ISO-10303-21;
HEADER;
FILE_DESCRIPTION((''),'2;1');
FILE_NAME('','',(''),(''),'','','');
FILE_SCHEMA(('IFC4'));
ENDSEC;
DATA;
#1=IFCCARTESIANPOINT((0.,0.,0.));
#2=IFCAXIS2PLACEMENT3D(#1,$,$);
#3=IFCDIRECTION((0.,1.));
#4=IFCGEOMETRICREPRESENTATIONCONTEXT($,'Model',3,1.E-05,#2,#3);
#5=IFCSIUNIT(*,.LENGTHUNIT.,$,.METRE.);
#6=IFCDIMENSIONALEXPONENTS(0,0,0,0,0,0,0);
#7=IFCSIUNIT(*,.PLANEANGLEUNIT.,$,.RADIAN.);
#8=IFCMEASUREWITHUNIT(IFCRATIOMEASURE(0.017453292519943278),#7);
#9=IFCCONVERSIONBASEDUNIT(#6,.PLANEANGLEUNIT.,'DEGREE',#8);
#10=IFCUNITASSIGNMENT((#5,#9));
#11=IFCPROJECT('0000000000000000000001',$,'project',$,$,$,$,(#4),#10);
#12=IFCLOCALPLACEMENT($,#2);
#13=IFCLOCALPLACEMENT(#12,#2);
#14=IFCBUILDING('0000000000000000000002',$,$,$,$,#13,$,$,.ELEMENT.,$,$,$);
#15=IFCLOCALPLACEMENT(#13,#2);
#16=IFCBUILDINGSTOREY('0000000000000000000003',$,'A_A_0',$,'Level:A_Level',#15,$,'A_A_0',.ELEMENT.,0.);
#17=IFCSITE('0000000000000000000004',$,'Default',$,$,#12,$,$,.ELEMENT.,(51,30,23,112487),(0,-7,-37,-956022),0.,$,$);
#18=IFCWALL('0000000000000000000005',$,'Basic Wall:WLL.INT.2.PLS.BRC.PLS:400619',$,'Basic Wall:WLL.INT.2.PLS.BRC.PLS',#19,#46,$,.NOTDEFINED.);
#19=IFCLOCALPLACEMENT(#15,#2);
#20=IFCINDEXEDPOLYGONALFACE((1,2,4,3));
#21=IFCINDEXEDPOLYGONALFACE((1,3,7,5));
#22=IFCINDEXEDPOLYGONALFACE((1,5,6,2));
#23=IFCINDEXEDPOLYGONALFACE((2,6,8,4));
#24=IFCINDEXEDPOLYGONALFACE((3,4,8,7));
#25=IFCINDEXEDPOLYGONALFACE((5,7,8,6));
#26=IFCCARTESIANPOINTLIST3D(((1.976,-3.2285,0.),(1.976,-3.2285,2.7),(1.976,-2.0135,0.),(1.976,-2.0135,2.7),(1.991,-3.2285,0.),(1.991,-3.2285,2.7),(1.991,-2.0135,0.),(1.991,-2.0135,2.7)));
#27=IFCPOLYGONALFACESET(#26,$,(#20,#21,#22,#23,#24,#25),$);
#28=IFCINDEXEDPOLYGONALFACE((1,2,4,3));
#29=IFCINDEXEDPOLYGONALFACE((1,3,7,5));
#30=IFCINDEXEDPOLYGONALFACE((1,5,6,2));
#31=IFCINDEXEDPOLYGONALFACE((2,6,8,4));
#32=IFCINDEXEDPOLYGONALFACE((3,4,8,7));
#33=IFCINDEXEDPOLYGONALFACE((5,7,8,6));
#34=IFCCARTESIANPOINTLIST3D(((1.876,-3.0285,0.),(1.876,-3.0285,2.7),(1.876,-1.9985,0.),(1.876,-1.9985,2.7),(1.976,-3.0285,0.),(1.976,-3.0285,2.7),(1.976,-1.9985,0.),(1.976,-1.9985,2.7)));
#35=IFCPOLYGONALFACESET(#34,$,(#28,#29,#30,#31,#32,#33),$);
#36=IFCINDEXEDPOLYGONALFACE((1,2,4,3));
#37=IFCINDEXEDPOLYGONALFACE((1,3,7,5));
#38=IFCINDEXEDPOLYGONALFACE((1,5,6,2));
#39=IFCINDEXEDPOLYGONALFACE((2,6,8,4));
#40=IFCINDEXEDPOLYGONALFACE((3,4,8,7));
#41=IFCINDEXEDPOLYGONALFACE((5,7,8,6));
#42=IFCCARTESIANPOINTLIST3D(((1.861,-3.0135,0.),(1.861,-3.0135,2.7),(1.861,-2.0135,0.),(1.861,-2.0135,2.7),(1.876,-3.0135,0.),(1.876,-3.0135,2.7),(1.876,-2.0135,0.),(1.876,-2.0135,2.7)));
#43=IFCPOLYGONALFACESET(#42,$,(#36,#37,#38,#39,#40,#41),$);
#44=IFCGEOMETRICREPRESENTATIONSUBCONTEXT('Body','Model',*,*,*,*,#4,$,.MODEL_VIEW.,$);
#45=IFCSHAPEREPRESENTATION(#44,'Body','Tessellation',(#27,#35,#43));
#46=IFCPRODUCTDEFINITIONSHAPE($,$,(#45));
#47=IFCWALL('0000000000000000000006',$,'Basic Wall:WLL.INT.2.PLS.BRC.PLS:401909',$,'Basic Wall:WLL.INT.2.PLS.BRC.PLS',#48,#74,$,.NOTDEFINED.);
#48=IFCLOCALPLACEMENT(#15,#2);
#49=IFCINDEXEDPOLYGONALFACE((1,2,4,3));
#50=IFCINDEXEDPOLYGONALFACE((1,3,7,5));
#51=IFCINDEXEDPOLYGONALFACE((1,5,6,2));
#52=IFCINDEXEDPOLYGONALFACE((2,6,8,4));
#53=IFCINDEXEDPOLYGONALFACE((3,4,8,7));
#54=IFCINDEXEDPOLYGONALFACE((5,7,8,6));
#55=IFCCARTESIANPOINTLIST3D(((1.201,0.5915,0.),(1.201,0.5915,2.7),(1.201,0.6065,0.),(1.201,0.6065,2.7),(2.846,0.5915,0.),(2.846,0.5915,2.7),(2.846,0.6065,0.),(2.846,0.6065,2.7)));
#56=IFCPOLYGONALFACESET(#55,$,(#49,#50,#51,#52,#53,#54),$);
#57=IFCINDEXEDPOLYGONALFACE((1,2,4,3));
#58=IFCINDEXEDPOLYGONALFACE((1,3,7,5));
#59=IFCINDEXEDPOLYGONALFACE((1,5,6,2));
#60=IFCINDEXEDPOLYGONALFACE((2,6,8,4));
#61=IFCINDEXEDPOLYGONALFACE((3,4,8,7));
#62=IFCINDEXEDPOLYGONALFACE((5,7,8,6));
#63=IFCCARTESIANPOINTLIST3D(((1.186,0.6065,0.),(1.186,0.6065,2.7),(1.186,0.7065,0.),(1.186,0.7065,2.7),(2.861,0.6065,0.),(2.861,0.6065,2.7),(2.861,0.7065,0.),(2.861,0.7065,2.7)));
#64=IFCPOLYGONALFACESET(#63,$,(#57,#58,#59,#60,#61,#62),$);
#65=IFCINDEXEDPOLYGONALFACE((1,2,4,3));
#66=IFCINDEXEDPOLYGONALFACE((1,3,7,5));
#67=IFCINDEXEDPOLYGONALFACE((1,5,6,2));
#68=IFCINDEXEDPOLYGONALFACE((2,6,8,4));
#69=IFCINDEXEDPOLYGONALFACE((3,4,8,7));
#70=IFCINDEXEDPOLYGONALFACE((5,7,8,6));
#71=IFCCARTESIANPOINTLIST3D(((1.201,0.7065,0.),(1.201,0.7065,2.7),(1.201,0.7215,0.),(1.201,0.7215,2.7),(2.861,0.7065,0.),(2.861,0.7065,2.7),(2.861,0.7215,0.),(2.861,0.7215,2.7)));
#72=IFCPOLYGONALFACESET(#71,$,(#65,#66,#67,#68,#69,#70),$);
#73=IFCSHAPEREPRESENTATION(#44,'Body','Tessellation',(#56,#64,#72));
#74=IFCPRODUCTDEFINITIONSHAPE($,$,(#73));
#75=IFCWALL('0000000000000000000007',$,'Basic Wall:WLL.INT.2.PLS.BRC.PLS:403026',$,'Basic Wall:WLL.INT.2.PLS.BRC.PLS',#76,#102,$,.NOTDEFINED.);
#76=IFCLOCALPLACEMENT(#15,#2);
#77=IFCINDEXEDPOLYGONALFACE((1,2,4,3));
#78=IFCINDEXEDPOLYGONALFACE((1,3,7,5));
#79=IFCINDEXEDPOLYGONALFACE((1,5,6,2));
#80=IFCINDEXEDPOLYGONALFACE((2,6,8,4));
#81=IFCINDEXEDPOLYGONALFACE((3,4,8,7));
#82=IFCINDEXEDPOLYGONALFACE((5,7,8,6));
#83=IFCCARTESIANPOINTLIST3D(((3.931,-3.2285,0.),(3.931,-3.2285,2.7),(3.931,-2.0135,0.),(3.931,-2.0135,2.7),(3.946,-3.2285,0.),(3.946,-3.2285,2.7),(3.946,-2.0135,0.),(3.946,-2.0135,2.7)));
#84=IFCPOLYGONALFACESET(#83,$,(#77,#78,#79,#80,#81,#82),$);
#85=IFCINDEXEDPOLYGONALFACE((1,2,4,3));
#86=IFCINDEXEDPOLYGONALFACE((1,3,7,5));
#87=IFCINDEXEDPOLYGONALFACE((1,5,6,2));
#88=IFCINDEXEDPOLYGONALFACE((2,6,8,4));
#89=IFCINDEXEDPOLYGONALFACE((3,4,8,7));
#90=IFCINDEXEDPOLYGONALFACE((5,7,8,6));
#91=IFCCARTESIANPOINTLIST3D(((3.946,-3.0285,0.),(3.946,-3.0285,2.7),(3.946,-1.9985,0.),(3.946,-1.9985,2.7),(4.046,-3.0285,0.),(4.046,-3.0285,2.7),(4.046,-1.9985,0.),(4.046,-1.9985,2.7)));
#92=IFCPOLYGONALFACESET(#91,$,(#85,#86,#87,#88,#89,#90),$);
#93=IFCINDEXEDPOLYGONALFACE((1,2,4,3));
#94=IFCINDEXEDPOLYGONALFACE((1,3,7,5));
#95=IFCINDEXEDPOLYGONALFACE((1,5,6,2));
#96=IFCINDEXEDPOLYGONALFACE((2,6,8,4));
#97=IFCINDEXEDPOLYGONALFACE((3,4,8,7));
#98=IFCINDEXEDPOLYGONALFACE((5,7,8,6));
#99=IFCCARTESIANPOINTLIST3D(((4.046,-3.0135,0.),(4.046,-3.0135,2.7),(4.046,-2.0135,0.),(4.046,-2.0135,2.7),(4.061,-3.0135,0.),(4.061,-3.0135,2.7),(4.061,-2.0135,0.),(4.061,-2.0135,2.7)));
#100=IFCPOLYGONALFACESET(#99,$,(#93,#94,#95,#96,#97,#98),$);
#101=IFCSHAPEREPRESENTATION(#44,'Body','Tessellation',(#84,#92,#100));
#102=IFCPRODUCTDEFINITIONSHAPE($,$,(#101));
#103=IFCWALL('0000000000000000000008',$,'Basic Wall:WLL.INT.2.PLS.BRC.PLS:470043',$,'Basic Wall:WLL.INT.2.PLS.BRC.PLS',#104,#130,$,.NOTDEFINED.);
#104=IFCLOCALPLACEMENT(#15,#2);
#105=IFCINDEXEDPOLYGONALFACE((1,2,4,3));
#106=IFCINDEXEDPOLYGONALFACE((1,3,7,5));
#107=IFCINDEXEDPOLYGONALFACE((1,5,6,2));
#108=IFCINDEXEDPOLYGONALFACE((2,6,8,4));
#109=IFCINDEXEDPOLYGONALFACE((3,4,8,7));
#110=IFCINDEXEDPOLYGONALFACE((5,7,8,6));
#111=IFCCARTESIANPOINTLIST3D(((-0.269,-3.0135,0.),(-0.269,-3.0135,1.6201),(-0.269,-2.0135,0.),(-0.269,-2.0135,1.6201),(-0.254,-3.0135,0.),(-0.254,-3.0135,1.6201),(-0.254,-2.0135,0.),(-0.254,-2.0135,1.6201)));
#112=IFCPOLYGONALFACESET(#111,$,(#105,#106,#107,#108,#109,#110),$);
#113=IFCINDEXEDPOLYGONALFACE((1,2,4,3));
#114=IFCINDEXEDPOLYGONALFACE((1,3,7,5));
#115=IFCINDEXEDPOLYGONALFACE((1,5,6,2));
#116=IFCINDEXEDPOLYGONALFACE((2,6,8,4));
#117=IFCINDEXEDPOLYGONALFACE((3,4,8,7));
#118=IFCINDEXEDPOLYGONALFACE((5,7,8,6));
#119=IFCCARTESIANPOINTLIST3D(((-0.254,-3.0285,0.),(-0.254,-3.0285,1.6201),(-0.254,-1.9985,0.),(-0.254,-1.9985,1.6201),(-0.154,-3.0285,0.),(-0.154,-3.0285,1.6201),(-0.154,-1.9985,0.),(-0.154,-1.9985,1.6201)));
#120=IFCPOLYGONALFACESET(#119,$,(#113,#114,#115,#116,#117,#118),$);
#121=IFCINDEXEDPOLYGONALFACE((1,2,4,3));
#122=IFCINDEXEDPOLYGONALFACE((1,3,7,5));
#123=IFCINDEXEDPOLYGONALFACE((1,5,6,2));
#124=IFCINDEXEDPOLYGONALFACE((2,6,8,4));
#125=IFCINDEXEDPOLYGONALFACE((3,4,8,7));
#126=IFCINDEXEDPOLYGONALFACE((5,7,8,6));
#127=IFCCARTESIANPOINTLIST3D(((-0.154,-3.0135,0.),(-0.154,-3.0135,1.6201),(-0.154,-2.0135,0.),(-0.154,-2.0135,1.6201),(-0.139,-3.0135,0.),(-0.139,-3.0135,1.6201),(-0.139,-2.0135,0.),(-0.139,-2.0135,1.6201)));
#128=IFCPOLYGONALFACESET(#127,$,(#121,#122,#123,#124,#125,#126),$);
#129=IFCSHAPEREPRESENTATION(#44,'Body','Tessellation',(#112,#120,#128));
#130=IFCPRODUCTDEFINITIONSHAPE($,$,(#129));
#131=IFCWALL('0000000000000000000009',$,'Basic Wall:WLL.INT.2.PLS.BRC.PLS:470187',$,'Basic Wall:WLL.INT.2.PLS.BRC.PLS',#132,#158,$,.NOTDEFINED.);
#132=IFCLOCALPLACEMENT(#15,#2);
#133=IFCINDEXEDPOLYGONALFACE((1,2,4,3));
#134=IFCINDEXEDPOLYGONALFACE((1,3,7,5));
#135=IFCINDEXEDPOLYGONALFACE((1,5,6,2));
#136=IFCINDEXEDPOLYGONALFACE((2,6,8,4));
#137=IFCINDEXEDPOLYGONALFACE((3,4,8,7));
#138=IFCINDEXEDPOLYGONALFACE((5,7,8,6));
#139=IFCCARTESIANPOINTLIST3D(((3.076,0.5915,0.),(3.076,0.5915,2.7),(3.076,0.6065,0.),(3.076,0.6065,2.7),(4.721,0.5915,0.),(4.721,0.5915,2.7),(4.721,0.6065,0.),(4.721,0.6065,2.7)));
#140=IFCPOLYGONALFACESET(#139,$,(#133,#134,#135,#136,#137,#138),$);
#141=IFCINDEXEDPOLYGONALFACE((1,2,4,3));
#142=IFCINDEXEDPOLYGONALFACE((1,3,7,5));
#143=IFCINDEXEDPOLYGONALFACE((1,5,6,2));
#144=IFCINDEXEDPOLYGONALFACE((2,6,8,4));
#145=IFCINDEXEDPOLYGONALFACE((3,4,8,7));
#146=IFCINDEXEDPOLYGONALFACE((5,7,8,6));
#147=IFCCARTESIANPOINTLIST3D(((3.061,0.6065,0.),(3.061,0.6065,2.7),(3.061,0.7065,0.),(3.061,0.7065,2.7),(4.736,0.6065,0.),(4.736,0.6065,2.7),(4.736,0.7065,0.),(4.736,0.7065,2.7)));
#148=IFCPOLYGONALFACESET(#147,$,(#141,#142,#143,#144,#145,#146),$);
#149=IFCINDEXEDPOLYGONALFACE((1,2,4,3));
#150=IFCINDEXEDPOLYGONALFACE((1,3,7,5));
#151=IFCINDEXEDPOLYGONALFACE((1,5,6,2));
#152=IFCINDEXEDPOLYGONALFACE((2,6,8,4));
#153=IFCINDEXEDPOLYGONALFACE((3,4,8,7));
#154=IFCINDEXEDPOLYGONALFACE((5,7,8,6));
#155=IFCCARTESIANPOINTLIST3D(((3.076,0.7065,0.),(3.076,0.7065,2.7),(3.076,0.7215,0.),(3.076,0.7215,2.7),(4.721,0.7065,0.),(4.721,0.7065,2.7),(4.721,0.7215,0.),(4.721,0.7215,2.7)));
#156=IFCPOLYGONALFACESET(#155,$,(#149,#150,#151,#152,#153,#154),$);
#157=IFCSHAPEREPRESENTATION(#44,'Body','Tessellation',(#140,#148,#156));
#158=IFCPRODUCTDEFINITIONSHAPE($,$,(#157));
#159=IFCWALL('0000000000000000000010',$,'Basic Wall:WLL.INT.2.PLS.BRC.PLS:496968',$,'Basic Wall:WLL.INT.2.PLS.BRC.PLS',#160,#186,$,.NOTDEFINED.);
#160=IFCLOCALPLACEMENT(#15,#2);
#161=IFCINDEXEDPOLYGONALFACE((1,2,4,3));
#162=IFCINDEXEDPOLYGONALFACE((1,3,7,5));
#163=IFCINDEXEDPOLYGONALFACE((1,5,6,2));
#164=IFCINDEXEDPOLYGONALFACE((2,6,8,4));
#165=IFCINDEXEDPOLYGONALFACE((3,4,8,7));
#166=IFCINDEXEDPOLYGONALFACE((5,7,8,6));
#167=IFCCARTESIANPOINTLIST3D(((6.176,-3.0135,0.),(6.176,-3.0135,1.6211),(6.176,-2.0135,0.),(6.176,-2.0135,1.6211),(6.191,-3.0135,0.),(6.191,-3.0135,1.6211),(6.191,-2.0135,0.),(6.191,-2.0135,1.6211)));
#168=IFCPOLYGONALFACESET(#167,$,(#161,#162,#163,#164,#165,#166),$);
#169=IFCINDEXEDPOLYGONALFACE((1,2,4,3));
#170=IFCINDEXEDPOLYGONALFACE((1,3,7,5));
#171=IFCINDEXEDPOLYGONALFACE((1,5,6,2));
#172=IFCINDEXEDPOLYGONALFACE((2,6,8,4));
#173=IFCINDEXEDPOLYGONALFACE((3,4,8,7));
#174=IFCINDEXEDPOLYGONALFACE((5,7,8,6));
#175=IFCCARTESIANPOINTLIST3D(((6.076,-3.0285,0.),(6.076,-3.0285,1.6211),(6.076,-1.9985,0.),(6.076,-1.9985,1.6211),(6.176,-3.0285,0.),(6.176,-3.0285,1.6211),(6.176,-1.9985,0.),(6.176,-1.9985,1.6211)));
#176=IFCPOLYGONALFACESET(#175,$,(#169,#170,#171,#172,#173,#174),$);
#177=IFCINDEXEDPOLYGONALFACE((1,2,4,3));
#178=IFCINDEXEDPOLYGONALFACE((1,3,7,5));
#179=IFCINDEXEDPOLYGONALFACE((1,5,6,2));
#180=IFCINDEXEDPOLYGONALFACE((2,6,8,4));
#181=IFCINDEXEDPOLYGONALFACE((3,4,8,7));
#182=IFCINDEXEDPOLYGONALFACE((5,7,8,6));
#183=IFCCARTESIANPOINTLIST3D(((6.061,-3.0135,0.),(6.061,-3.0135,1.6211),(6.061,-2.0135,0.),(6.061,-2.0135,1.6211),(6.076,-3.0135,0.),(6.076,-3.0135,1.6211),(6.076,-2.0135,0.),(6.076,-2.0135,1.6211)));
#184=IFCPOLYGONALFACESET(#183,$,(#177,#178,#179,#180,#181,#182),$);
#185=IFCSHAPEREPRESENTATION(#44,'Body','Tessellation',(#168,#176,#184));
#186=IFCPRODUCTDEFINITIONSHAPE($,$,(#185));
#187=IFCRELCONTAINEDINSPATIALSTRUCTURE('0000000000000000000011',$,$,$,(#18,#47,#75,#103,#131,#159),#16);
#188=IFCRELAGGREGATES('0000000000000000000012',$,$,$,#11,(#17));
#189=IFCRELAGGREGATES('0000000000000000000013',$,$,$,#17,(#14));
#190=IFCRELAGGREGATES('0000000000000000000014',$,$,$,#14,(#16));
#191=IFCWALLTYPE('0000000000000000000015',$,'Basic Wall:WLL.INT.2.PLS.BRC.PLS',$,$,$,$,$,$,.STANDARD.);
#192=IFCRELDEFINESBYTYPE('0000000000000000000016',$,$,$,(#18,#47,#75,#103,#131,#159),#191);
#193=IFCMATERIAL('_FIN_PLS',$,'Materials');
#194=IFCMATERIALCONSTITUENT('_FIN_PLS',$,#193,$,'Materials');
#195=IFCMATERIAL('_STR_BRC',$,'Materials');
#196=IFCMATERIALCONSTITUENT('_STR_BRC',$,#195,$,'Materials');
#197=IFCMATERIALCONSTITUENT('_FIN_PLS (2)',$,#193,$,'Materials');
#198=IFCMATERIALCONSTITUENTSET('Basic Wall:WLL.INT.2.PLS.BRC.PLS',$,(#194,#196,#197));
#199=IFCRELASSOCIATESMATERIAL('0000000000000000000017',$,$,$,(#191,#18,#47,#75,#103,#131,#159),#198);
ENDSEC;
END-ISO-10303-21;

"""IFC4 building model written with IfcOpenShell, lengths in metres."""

from ifc_helpers import new_model, entity, si_unit, converted_unit, direction, frame, origin, place, context, subcontext, project, spatial, indexed_curve, outline, extrude, material, constituent, constituent_set, type_object, element, save


model = new_model("IFC4")

# Units and contexts
model_context = context("Model", 3, precision=1e-05, world=origin(), true_north=direction((0.0, 1.0)))
body_context = subcontext(model_context, "Body", "Model", "MODEL_VIEW")
ifc_project = project(units=[si_unit("LENGTHUNIT", "METRE"), converted_unit("PLANEANGLEUNIT", "DEGREE", entity("IfcRatioMeasure", 0.017453292519943278), si_unit("PLANEANGLEUNIT", "RADIAN"), dimensions=[0, 0, 0, 0, 0, 0, 0])], contexts=[model_context])

# Site, building, storey
site_placement = place(None, origin())
site = spatial("IfcSite", under=ifc_project, at=site_placement, Name="Default", CompositionType="ELEMENT", RefLatitude=(51, 30, 23, 112487), RefLongitude=(0, -7, -37, -956022), RefElevation=0.0)
building_placement = place(site_placement, origin())
building = spatial("IfcBuilding", under=site, at=building_placement, CompositionType="ELEMENT")
storey_placement = place(building_placement, origin())
storey = spatial("IfcBuildingStorey", under=building, at=storey_placement, Name="A_A_0", ObjectType="Level:A_Level", LongName="A_A_0", CompositionType="ELEMENT", Elevation=0.0)

# Shared definitions
ifc_material_1 = material(Name="_FIN_PLS", Category="Materials")
ifc_material_2 = material(Name="_STR_BRC", Category="Materials")

# Walls
ifc_constituent_1 = constituent(ifc_material_1, Name="_FIN_PLS", Category="Materials")
ifc_constituent_2 = constituent(ifc_material_2, Name="_STR_BRC", Category="Materials")
ifc_constituent_3 = constituent(ifc_material_1, Name="_FIN_PLS (2)", Category="Materials")
ifc_constituent_set_1 = constituent_set(constituents=[ifc_constituent_1, ifc_constituent_2, ifc_constituent_3], Name="Basic Wall:WLL.INT.2.PLS.BRC.PLS")
wall_type_1 = type_object("IfcWallType", Name="Basic Wall:WLL.INT.2.PLS.BRC.PLS", PredefinedType="STANDARD", material=ifc_constituent_set_1)
wall_1_placement = place(storey_placement, frame((1.926, -2.0135, 0.0), z_axis=(0.0, 0.0, 1.0), x_axis=(0.0, -1.0, 0.0)))
element("IfcWall", 1, at=wall_1_placement, inside=storey, type_object=wall_type_1, material=ifc_constituent_set_1, Name="Basic Wall:WLL.INT.2.PLS.BRC.PLS:400619", ObjectType="Basic Wall:WLL.INT.2.PLS.BRC.PLS", PredefinedType="NOTDEFINED", context=body_context, shape_type="SweptSolid", body=[
    extrude(outline(indexed_curve([(-0.0075, -0.6075), (0.0075, -0.6075), (0.0075, 0.6075), (-0.0075, 0.6075), (-0.0075, -0.6075)], self_intersect=False)), frame((0.6075, 0.0575, 0.0), z_axis=(0.0, 0.0, 1.0), x_axis=(0.0, -1.0, 0.0)), (0.0, 0.0, 1.0), 2.7),
    extrude(outline(indexed_curve([(-0.515, -0.05), (0.515, -0.05), (0.515, 0.05), (-0.515, 0.05), (-0.515, -0.05)], self_intersect=False)), frame((0.5, 0.0, 0.0)), (0.0, 0.0, 1.0), 2.7),
    extrude(outline(indexed_curve([(-0.0075, -0.5), (0.0075, -0.5), (0.0075, 0.5), (-0.0075, 0.5), (-0.0075, -0.5)], self_intersect=False)), frame((0.5, -0.0575, 0.0), z_axis=(0.0, 0.0, 1.0), x_axis=(0.0, 1.0, 0.0)), (0.0, 0.0, 1.0), 2.7),
])
wall_2_placement = place(storey_placement, frame((1.201, 0.6565, 0.0)))
element("IfcWall", 2, at=wall_2_placement, inside=storey, type_object=wall_type_1, material=ifc_constituent_set_1, Name="Basic Wall:WLL.INT.2.PLS.BRC.PLS:401909", ObjectType="Basic Wall:WLL.INT.2.PLS.BRC.PLS", PredefinedType="NOTDEFINED", context=body_context, shape_type="SweptSolid", body=[
    extrude(outline(indexed_curve([(-0.0075, -0.8225), (0.0075, -0.8225), (0.0075, 0.8225), (-0.0075, 0.8225), (-0.0075, -0.8225)], self_intersect=False)), frame((0.8225, -0.0575, 0.0), z_axis=(0.0, 0.0, 1.0), x_axis=(0.0, 1.0, 0.0)), (0.0, 0.0, 1.0), 2.7),
    extrude(outline(indexed_curve([(-0.8375, -0.05), (0.8375, -0.05), (0.8375, 0.05), (-0.8375, 0.05), (-0.8375, -0.05)], self_intersect=False)), frame((0.8225, 0.0, 0.0)), (0.0, 0.0, 1.0), 2.7),
    extrude(outline(indexed_curve([(-0.0075, -0.83), (0.0075, -0.83), (0.0075, 0.83), (-0.0075, 0.83), (-0.0075, -0.83)], self_intersect=False)), frame((0.83, 0.0575, 0.0), z_axis=(0.0, 0.0, 1.0), x_axis=(0.0, -1.0, 0.0)), (0.0, 0.0, 1.0), 2.7),
])
wall_3_placement = place(storey_placement, frame((3.996, -2.0135, 0.0), z_axis=(0.0, 0.0, 1.0), x_axis=(0.0, -1.0, 0.0)))
element("IfcWall", 3, at=wall_3_placement, inside=storey, type_object=wall_type_1, material=ifc_constituent_set_1, Name="Basic Wall:WLL.INT.2.PLS.BRC.PLS:403026", ObjectType="Basic Wall:WLL.INT.2.PLS.BRC.PLS", PredefinedType="NOTDEFINED", context=body_context, shape_type="SweptSolid", body=[
    extrude(outline(indexed_curve([(-0.0075, -0.6075), (0.0075, -0.6075), (0.0075, 0.6075), (-0.0075, 0.6075), (-0.0075, -0.6075)], self_intersect=False)), frame((0.6075, -0.0575, 0.0), z_axis=(0.0, 0.0, 1.0), x_axis=(0.0, 1.0, 0.0)), (0.0, 0.0, 1.0), 2.7),
    extrude(outline(indexed_curve([(-0.515, -0.05), (0.515, -0.05), (0.515, 0.05), (-0.515, 0.05), (-0.515, -0.05)], self_intersect=False)), frame((0.5, 0.0, 0.0)), (0.0, 0.0, 1.0), 2.7),
    extrude(outline(indexed_curve([(-0.0075, -0.5), (0.0075, -0.5), (0.0075, 0.5), (-0.0075, 0.5), (-0.0075, -0.5)], self_intersect=False)), frame((0.5, 0.0575, 0.0), z_axis=(0.0, 0.0, 1.0), x_axis=(0.0, -1.0, 0.0)), (0.0, 0.0, 1.0), 2.7),
])
wall_4_placement = place(storey_placement, frame((-0.204, -2.0135, 0.0), z_axis=(0.0, 0.0, 1.0), x_axis=(0.0, -1.0, 0.0)))
element("IfcWall", 4, at=wall_4_placement, inside=storey, type_object=wall_type_1, material=ifc_constituent_set_1, Name="Basic Wall:WLL.INT.2.PLS.BRC.PLS:470043", ObjectType="Basic Wall:WLL.INT.2.PLS.BRC.PLS", PredefinedType="NOTDEFINED", context=body_context, shape_type="SweptSolid", body=[
    extrude(outline(indexed_curve([(-0.0075, -0.5), (0.0075, -0.5), (0.0075, 0.5), (-0.0075, 0.5), (-0.0075, -0.5)], self_intersect=False)), frame((0.5, -0.0575, 0.0), z_axis=(0.0, 0.0, 1.0), x_axis=(0.0, 1.0, 0.0)), (0.0, 0.0, 1.0), 1.6201),
    extrude(outline(indexed_curve([(-0.515, -0.05), (0.515, -0.05), (0.515, 0.05), (-0.515, 0.05), (-0.515, -0.05)], self_intersect=False)), frame((0.5, 0.0, 0.0)), (0.0, 0.0, 1.0), 1.6201),
    extrude(outline(indexed_curve([(-0.0075, -0.5), (0.0075, -0.5), (0.0075, 0.5), (-0.0075, 0.5), (-0.0075, -0.5)], self_intersect=False)), frame((0.5, 0.0575, 0.0), z_axis=(0.0, 0.0, 1.0), x_axis=(0.0, -1.0, 0.0)), (0.0, 0.0, 1.0), 1.6201),
])
wall_5_placement = place(storey_placement, frame((4.721, 0.6565, 0.0), z_axis=(0.0, 0.0, 1.0), x_axis=(-1.0, 0.0, 0.0)))
element("IfcWall", 5, at=wall_5_placement, inside=storey, type_object=wall_type_1, material=ifc_constituent_set_1, Name="Basic Wall:WLL.INT.2.PLS.BRC.PLS:470187", ObjectType="Basic Wall:WLL.INT.2.PLS.BRC.PLS", PredefinedType="NOTDEFINED", context=body_context, shape_type="SweptSolid", body=[
    extrude(outline(indexed_curve([(-0.0075, -0.8225), (0.0075, -0.8225), (0.0075, 0.8225), (-0.0075, 0.8225), (-0.0075, -0.8225)], self_intersect=False)), frame((0.8225, 0.0575, 0.0), z_axis=(0.0, 0.0, 1.0), x_axis=(0.0, -1.0, 0.0)), (0.0, 0.0, 1.0), 2.7),
    extrude(outline(indexed_curve([(-0.8375, -0.05), (0.8375, -0.05), (0.8375, 0.05), (-0.8375, 0.05), (-0.8375, -0.05)], self_intersect=False)), frame((0.8225, 0.0, 0.0)), (0.0, 0.0, 1.0), 2.7),
    extrude(outline(indexed_curve([(-0.0075, -0.8225), (0.0075, -0.8225), (0.0075, 0.8225), (-0.0075, 0.8225), (-0.0075, -0.8225)], self_intersect=False)), frame((0.8225, -0.0575, 0.0), z_axis=(0.0, 0.0, 1.0), x_axis=(0.0, 1.0, 0.0)), (0.0, 0.0, 1.0), 2.7),
])
wall_6_placement = place(storey_placement, frame((6.126, -2.0135, 0.0), z_axis=(0.0, 0.0, 1.0), x_axis=(0.0, -1.0, 0.0)))
element("IfcWall", 6, at=wall_6_placement, inside=storey, type_object=wall_type_1, material=ifc_constituent_set_1, Name="Basic Wall:WLL.INT.2.PLS.BRC.PLS:496968", ObjectType="Basic Wall:WLL.INT.2.PLS.BRC.PLS", PredefinedType="NOTDEFINED", context=body_context, shape_type="SweptSolid", body=[
    extrude(outline(indexed_curve([(-0.0075, -0.5), (0.0075, -0.5), (0.0075, 0.5), (-0.0075, 0.5), (-0.0075, -0.5)], self_intersect=False)), frame((0.5, 0.0575, 0.0), z_axis=(0.0, 0.0, 1.0), x_axis=(0.0, -1.0, 0.0)), (0.0, 0.0, 1.0), 1.6211),
    extrude(outline(indexed_curve([(-0.515, -0.05), (0.515, -0.05), (0.515, 0.05), (-0.515, 0.05), (-0.515, -0.05)], self_intersect=False)), frame((0.5, 0.0, 0.0)), (0.0, 0.0, 1.0), 1.6211),
    extrude(outline(indexed_curve([(-0.0075, -0.5), (0.0075, -0.5), (0.0075, 0.5), (-0.0075, 0.5), (-0.0075, -0.5)], self_intersect=False)), frame((0.5, -0.0575, 0.0), z_axis=(0.0, 0.0, 1.0), x_axis=(0.0, 1.0, 0.0)), (0.0, 0.0, 1.0), 1.6211),
])

save(model, "model.ifc")
